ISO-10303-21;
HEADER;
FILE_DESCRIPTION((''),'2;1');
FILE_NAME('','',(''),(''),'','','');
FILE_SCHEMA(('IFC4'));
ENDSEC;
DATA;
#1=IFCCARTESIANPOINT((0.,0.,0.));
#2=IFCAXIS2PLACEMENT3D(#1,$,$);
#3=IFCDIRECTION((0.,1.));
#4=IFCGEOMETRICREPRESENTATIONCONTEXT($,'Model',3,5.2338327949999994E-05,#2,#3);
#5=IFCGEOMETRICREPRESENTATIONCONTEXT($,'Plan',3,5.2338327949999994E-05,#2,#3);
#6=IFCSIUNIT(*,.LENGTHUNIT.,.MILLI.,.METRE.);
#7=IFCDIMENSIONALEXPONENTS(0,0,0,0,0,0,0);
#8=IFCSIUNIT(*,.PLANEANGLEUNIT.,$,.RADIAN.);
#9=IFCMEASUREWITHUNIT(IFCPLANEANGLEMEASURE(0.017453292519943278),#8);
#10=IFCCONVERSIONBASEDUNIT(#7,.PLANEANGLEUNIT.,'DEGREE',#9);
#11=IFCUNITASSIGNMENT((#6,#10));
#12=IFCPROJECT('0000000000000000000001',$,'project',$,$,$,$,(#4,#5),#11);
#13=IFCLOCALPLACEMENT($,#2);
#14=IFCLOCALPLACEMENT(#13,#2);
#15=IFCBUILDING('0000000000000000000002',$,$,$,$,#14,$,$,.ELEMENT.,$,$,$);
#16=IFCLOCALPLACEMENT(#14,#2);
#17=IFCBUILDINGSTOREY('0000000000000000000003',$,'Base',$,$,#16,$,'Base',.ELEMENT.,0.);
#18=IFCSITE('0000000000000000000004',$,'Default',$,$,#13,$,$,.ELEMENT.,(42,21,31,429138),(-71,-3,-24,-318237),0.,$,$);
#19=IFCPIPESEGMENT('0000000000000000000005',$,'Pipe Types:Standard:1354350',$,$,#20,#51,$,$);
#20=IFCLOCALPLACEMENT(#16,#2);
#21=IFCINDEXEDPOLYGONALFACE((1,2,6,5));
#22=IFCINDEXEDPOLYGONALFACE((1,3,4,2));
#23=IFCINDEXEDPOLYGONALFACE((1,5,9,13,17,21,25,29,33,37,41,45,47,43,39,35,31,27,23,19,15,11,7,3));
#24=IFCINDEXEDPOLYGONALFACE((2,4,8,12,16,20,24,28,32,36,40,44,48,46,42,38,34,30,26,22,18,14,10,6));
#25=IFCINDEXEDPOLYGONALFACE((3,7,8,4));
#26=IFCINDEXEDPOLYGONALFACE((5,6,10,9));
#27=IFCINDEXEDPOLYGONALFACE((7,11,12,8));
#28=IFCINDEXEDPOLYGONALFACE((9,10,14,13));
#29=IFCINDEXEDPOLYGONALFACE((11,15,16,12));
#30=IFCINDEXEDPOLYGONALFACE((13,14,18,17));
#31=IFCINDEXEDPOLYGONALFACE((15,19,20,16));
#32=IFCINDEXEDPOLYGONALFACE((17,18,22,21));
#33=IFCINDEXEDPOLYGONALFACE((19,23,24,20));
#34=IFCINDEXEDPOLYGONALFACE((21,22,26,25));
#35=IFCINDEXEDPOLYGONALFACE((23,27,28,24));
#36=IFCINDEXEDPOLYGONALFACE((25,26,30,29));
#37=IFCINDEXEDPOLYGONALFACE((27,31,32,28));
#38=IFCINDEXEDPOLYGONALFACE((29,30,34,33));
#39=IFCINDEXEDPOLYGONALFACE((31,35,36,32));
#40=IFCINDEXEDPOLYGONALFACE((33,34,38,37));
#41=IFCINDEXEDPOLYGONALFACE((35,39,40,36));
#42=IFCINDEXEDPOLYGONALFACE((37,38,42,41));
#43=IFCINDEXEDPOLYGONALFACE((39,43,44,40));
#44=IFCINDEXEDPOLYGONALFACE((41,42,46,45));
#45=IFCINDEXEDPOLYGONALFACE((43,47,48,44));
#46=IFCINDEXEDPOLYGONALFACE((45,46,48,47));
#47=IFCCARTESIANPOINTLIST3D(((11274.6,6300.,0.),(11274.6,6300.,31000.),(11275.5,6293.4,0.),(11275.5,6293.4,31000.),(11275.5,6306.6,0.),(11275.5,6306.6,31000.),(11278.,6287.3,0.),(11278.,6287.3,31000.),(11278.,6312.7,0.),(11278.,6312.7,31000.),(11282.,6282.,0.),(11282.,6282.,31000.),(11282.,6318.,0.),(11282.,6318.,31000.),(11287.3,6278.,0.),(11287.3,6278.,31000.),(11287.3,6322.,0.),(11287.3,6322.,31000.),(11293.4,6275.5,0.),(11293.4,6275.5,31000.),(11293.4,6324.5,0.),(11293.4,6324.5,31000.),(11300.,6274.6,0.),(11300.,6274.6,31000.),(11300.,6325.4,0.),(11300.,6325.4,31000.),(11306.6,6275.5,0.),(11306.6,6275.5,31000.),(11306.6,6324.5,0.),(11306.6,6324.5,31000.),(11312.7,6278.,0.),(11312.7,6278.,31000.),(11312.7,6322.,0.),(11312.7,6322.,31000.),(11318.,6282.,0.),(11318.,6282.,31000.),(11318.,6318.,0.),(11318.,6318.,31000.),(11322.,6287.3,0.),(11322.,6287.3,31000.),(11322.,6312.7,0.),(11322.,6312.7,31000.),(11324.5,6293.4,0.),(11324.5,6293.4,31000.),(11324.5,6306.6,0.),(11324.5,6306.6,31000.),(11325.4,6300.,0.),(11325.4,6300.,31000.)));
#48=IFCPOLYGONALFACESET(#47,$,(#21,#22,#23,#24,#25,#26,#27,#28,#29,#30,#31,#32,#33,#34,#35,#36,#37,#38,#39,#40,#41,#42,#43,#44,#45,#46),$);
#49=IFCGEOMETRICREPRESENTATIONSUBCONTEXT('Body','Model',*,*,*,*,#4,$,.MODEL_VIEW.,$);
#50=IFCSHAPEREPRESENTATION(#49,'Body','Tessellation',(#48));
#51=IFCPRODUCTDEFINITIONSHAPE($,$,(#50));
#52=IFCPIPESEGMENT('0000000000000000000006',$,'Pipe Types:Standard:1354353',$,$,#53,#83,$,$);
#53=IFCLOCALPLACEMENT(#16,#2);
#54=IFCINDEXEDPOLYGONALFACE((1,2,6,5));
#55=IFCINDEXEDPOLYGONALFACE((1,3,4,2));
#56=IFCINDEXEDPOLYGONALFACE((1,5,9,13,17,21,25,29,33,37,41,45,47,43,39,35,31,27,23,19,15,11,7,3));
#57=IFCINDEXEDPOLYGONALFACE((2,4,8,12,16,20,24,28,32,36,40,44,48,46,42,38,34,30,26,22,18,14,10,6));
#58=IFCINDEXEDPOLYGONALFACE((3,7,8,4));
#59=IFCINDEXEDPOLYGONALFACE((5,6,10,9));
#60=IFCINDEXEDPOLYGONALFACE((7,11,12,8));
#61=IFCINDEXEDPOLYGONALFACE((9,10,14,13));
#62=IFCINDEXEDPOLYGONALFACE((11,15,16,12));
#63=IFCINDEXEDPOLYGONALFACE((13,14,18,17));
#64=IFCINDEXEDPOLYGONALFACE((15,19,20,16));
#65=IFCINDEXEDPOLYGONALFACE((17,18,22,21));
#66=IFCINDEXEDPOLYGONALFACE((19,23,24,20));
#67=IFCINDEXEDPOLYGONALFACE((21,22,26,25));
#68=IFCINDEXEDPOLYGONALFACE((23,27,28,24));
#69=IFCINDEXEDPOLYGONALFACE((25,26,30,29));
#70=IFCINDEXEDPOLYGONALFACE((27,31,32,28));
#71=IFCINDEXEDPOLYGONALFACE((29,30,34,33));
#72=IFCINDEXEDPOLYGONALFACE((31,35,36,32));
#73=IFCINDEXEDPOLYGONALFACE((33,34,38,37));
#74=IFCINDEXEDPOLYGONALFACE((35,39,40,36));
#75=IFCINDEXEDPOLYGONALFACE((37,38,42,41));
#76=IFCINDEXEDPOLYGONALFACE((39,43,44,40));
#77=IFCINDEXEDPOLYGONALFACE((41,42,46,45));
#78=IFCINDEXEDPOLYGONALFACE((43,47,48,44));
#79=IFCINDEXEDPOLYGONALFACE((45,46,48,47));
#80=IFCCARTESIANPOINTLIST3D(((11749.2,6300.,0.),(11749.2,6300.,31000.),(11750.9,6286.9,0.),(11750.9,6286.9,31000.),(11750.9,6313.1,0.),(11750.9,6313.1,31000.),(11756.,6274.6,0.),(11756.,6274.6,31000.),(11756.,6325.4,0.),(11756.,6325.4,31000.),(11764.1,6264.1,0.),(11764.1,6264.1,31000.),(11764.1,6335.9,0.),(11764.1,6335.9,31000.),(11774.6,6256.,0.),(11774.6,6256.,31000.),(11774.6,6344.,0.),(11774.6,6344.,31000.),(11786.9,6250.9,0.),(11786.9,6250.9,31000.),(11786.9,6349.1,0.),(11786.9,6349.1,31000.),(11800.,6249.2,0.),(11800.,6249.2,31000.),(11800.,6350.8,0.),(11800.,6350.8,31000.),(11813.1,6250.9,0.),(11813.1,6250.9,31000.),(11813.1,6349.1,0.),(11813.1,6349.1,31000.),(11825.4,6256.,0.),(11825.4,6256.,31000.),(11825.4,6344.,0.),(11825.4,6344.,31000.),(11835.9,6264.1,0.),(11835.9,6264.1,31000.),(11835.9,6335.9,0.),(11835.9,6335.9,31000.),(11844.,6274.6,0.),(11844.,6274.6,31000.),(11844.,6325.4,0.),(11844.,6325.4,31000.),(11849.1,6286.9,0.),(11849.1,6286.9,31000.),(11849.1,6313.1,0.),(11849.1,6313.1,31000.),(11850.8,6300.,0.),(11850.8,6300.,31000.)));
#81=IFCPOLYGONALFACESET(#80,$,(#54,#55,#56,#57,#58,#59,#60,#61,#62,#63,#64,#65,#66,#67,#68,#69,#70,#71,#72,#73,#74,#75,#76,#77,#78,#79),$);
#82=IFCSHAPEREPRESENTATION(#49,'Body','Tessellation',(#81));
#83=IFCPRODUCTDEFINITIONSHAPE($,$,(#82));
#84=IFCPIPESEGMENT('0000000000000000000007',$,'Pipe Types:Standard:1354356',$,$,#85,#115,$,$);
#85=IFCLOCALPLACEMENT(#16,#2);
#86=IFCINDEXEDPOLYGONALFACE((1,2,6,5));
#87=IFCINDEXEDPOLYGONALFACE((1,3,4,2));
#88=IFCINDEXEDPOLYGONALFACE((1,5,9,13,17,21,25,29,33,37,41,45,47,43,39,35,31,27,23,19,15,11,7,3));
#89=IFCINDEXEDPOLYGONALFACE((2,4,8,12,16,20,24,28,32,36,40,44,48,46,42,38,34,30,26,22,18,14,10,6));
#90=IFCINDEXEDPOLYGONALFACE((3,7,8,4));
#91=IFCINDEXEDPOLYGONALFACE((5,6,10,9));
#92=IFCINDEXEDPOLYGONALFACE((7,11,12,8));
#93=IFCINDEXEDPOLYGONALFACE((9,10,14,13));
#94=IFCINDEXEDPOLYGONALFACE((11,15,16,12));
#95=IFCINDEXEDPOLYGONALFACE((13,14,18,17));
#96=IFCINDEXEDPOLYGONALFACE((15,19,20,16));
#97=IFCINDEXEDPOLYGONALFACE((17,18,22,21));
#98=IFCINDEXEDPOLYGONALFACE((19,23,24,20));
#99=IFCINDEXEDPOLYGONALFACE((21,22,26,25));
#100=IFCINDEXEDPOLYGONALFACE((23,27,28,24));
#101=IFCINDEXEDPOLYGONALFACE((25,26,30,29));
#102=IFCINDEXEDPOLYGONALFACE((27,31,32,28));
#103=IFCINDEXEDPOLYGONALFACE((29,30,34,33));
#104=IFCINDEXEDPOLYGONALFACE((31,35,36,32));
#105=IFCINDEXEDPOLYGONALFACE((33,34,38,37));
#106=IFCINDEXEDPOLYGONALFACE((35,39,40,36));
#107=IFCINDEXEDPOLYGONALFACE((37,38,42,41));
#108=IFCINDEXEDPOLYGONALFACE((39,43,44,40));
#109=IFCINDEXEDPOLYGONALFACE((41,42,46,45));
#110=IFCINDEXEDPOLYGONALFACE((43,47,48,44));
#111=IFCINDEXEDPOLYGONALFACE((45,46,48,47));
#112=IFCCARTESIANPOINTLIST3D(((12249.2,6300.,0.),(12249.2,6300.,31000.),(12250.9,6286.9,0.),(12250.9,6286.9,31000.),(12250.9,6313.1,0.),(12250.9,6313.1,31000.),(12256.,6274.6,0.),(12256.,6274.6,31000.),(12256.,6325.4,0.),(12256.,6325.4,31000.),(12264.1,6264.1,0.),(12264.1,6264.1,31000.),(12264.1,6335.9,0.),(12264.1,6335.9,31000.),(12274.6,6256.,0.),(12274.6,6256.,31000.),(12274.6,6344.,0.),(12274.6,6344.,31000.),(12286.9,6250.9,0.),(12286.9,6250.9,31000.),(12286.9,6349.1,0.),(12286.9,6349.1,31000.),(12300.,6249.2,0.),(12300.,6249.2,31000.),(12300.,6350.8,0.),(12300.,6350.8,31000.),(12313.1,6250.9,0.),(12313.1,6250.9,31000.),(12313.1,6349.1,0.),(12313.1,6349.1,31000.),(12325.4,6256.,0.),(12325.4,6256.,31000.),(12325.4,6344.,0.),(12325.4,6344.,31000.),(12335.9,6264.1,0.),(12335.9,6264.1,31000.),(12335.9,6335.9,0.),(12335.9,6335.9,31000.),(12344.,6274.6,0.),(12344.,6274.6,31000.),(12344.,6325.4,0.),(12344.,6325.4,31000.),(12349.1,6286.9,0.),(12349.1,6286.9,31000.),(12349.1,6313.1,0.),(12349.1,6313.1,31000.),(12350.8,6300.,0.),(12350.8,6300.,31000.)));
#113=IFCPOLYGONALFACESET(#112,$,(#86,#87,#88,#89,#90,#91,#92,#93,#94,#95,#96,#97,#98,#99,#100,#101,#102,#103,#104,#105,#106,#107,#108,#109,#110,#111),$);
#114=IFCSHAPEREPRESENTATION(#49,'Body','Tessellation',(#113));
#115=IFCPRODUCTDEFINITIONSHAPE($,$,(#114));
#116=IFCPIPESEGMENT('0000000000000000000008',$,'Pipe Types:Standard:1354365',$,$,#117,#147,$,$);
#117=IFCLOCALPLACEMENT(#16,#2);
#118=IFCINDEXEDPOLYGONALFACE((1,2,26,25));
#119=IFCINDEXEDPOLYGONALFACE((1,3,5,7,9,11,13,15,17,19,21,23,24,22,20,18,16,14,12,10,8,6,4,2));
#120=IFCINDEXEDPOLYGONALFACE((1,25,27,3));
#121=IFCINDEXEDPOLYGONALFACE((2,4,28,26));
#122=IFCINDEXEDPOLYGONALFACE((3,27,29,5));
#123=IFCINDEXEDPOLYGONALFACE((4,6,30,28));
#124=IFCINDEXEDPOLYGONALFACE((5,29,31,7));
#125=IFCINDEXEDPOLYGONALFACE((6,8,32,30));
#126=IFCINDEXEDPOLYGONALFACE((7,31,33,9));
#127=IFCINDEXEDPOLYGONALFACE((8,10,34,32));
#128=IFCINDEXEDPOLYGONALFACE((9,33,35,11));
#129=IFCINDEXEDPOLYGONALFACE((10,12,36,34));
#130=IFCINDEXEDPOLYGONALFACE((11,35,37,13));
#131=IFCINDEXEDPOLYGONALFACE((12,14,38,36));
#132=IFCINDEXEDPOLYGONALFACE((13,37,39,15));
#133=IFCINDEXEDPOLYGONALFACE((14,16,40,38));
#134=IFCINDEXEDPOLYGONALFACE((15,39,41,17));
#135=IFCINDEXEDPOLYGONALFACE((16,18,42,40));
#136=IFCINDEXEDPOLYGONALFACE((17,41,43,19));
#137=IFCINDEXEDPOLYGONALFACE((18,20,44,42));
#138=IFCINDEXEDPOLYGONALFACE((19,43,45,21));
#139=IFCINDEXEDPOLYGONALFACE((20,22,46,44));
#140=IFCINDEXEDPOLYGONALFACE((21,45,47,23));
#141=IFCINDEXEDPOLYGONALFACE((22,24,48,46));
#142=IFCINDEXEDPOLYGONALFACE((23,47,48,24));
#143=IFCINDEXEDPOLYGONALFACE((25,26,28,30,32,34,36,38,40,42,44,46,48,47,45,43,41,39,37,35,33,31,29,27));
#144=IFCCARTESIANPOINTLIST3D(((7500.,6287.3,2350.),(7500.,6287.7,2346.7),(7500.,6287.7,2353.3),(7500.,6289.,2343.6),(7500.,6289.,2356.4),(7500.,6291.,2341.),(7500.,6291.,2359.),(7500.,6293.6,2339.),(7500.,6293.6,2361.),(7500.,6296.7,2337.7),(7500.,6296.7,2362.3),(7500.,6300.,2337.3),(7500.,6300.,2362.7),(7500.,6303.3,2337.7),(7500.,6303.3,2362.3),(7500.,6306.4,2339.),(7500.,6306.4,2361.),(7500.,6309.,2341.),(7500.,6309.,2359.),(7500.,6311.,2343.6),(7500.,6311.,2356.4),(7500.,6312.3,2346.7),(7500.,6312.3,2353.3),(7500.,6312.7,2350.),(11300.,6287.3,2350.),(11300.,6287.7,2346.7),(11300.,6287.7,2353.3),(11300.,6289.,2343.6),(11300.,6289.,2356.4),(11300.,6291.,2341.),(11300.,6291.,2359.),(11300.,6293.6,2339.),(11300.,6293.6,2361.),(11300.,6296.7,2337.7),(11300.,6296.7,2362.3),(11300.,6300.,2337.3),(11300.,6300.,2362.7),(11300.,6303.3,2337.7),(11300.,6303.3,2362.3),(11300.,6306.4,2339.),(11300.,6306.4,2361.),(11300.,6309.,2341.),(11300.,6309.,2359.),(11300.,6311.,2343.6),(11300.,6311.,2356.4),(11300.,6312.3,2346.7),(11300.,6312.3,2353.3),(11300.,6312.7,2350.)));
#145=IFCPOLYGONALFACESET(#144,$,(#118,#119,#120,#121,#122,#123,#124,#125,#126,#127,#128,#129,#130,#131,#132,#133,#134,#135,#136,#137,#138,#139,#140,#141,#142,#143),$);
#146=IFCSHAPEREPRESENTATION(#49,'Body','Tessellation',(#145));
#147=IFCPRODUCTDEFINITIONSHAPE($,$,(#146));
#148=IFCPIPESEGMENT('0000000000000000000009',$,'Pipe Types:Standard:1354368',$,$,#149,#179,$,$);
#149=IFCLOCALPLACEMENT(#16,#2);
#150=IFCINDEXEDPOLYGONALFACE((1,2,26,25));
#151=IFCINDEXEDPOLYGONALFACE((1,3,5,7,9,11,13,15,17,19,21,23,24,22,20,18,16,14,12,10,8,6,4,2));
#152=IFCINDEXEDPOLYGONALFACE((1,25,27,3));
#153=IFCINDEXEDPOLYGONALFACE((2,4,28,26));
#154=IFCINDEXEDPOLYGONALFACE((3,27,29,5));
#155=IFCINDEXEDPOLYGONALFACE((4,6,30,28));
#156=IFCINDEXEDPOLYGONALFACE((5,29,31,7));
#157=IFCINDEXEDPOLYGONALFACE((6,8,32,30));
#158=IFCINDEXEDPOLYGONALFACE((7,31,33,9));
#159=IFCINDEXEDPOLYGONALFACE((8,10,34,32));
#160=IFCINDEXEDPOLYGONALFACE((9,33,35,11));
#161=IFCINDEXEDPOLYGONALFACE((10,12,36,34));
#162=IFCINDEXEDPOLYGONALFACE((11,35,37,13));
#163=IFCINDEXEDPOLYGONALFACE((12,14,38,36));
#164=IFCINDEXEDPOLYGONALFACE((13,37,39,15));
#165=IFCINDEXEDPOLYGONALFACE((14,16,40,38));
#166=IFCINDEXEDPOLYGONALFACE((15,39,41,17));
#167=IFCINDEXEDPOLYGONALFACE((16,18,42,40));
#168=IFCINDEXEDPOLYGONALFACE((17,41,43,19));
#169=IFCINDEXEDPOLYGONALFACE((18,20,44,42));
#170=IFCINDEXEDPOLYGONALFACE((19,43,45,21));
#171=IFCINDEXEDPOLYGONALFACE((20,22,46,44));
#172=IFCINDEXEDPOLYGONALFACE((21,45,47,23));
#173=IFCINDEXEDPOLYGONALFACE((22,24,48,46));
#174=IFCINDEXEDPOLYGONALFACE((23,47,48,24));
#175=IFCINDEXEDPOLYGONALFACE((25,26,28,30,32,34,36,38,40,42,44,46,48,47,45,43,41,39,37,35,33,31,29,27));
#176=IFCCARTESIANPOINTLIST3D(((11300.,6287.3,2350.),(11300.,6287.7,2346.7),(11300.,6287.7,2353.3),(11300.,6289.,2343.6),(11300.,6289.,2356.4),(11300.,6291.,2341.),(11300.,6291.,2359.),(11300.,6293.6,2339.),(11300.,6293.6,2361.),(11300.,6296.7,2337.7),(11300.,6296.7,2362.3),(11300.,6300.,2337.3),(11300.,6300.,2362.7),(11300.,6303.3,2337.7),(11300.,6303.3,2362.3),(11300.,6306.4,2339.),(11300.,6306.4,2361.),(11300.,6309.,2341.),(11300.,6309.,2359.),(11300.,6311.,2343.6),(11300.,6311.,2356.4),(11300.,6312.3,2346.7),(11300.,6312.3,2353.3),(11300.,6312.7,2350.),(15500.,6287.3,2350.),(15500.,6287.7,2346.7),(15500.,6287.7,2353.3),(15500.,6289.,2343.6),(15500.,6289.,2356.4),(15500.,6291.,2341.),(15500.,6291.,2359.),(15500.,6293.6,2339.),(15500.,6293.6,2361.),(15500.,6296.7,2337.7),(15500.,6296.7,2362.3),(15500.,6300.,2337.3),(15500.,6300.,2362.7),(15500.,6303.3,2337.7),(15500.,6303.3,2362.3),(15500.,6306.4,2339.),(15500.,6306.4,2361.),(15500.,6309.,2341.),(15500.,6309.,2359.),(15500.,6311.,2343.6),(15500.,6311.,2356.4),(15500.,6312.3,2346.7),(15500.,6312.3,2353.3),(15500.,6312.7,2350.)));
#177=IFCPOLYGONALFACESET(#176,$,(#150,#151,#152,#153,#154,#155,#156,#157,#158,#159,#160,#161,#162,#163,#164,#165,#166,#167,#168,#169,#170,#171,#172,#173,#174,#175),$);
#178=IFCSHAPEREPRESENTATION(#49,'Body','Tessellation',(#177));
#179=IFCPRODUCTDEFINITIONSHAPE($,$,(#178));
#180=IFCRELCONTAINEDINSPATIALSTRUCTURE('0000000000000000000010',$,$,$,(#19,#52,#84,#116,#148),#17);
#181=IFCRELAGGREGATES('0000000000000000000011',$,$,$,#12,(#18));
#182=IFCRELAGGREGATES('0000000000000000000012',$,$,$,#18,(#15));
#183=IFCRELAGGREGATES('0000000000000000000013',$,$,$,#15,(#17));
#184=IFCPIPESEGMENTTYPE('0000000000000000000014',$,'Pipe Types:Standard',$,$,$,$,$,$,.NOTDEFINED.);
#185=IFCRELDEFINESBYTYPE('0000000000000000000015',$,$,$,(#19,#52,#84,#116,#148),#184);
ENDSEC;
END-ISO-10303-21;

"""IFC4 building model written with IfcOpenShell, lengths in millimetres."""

from ifc_helpers import new_model, entity, si_unit, converted_unit, direction, frame, origin, place, context, subcontext, project, spatial, arc, indexed_curve, outline, extrude, type_object, element, save


model = new_model("IFC4")

# Units and contexts
model_context = context("Model", 3, precision=5.2338327949999994e-05, world=origin(), true_north=direction((0.0, 1.0)))
plan_context = context("Plan", 3, precision=5.2338327949999994e-05, world=origin(), true_north=direction((0.0, 1.0)))
body_context = subcontext(model_context, "Body", "Model", "MODEL_VIEW")
ifc_project = project(units=[si_unit("LENGTHUNIT", "METRE", prefix="MILLI"), converted_unit("PLANEANGLEUNIT", "DEGREE", entity("IfcPlaneAngleMeasure", 0.017453292519943278), si_unit("PLANEANGLEUNIT", "RADIAN"), dimensions=[0, 0, 0, 0, 0, 0, 0])], contexts=[model_context, plan_context])

# Site, building, storey
site_placement = place(None, origin())
site = spatial("IfcSite", under=ifc_project, at=site_placement, Name="Default", CompositionType="ELEMENT", RefLatitude=(42, 21, 31, 429138), RefLongitude=(-71, -3, -24, -318237), RefElevation=0.0)
building_placement = place(site_placement, origin())
building = spatial("IfcBuilding", under=site, at=building_placement, CompositionType="ELEMENT")
storey_placement = place(building_placement, origin())
storey = spatial("IfcBuildingStorey", under=building, at=storey_placement, Name="Base", LongName="Base", CompositionType="ELEMENT", Elevation=0.0)

# Pipe segments
pipe_segment_type = type_object("IfcPipeSegmentType", Name="Pipe Types:Standard", PredefinedType="NOTDEFINED")
pipe_segment_1_placement = place(storey_placement, origin())
element("IfcPipeSegment", 1, at=pipe_segment_1_placement, inside=storey, type_object=pipe_segment_type, Name="Pipe Types:Standard:1354350", context=body_context, shape_type="SweptSolid", body=[
    extrude(outline(indexed_curve([(25.4, 0.0), (18.0, 18.0), (0.0, 25.4), (-18.0, 18.0), (-25.4, 0.0), (-18.0, -18.0), (0.0, -25.4), (18.0, -18.0)], segments=[arc(1, 2, 3), arc(3, 4, 5), arc(5, 6, 7), arc(7, 8, 1)], self_intersect=False)), frame((11300.0, 6300.0, 0.0), z_axis=(0.0, 0.0, 1.0), x_axis=(-1.0, 0.0, 0.0)), (0.0, 0.0, 1.0), 31000.0),
])
pipe_segment_2_placement = place(storey_placement, origin())
element("IfcPipeSegment", 2, at=pipe_segment_2_placement, inside=storey, type_object=pipe_segment_type, Name="Pipe Types:Standard:1354353", context=body_context, shape_type="SweptSolid", body=[
    extrude(outline(indexed_curve([(50.8, 0.0), (35.9, 35.9), (0.0, 50.8), (-35.9, 35.9), (-50.8, 0.0), (-35.9, -35.9), (0.0, -50.8), (35.9, -35.9)], segments=[arc(1, 2, 3), arc(3, 4, 5), arc(5, 6, 7), arc(7, 8, 1)], self_intersect=False)), frame((11800.0, 6300.0, 0.0), z_axis=(0.0, 0.0, 1.0), x_axis=(-1.0, 0.0, 0.0)), (0.0, 0.0, 1.0), 31000.0),
])
pipe_segment_3_placement = place(storey_placement, origin())
element("IfcPipeSegment", 3, at=pipe_segment_3_placement, inside=storey, type_object=pipe_segment_type, Name="Pipe Types:Standard:1354356", context=body_context, shape_type="SweptSolid", body=[
    extrude(outline(indexed_curve([(50.8, 0.0), (35.9, 35.9), (0.0, 50.8), (-35.9, 35.9), (-50.8, 0.0), (-35.9, -35.9), (0.0, -50.8), (35.9, -35.9)], segments=[arc(1, 2, 3), arc(3, 4, 5), arc(5, 6, 7), arc(7, 8, 1)], self_intersect=False)), frame((12300.0, 6300.0, 0.0), z_axis=(0.0, 0.0, 1.0), x_axis=(-1.0, 0.0, 0.0)), (0.0, 0.0, 1.0), 31000.0),
])
pipe_segment_4_placement = place(storey_placement, origin())
element("IfcPipeSegment", 4, at=pipe_segment_4_placement, inside=storey, type_object=pipe_segment_type, Name="Pipe Types:Standard:1354365", context=body_context, shape_type="SweptSolid", body=[
    extrude(outline(indexed_curve([(12.7, 0.0), (9.0, 9.0), (0.0, 12.7), (-9.0, 9.0), (-12.7, 0.0), (-9.0, -9.0), (0.0, -12.7), (9.0, -9.0)], segments=[arc(1, 2, 3), arc(3, 4, 5), arc(5, 6, 7), arc(7, 8, 1)], self_intersect=False)), frame((7500.0, 6300.0, 2350.0), z_axis=(1.0, 0.0, 0.0), x_axis=(0.0, 1.0, 0.0)), (0.0, 0.0, 1.0), 3800.0),
])
pipe_segment_5_placement = place(storey_placement, origin())
element("IfcPipeSegment", 5, at=pipe_segment_5_placement, inside=storey, type_object=pipe_segment_type, Name="Pipe Types:Standard:1354368", context=body_context, shape_type="SweptSolid", body=[
    extrude(outline(indexed_curve([(12.7, 0.0), (9.0, 9.0), (0.0, 12.7), (-9.0, 9.0), (-12.7, 0.0), (-9.0, -9.0), (0.0, -12.7), (9.0, -9.0)], segments=[arc(1, 2, 3), arc(3, 4, 5), arc(5, 6, 7), arc(7, 8, 1)], self_intersect=False)), frame((11300.0, 6300.0, 2350.0), z_axis=(1.0, 0.0, 0.0), x_axis=(0.0, -1.0, 0.0)), (0.0, 0.0, 1.0), 4200.0),
])

save(model, "model.ifc")
